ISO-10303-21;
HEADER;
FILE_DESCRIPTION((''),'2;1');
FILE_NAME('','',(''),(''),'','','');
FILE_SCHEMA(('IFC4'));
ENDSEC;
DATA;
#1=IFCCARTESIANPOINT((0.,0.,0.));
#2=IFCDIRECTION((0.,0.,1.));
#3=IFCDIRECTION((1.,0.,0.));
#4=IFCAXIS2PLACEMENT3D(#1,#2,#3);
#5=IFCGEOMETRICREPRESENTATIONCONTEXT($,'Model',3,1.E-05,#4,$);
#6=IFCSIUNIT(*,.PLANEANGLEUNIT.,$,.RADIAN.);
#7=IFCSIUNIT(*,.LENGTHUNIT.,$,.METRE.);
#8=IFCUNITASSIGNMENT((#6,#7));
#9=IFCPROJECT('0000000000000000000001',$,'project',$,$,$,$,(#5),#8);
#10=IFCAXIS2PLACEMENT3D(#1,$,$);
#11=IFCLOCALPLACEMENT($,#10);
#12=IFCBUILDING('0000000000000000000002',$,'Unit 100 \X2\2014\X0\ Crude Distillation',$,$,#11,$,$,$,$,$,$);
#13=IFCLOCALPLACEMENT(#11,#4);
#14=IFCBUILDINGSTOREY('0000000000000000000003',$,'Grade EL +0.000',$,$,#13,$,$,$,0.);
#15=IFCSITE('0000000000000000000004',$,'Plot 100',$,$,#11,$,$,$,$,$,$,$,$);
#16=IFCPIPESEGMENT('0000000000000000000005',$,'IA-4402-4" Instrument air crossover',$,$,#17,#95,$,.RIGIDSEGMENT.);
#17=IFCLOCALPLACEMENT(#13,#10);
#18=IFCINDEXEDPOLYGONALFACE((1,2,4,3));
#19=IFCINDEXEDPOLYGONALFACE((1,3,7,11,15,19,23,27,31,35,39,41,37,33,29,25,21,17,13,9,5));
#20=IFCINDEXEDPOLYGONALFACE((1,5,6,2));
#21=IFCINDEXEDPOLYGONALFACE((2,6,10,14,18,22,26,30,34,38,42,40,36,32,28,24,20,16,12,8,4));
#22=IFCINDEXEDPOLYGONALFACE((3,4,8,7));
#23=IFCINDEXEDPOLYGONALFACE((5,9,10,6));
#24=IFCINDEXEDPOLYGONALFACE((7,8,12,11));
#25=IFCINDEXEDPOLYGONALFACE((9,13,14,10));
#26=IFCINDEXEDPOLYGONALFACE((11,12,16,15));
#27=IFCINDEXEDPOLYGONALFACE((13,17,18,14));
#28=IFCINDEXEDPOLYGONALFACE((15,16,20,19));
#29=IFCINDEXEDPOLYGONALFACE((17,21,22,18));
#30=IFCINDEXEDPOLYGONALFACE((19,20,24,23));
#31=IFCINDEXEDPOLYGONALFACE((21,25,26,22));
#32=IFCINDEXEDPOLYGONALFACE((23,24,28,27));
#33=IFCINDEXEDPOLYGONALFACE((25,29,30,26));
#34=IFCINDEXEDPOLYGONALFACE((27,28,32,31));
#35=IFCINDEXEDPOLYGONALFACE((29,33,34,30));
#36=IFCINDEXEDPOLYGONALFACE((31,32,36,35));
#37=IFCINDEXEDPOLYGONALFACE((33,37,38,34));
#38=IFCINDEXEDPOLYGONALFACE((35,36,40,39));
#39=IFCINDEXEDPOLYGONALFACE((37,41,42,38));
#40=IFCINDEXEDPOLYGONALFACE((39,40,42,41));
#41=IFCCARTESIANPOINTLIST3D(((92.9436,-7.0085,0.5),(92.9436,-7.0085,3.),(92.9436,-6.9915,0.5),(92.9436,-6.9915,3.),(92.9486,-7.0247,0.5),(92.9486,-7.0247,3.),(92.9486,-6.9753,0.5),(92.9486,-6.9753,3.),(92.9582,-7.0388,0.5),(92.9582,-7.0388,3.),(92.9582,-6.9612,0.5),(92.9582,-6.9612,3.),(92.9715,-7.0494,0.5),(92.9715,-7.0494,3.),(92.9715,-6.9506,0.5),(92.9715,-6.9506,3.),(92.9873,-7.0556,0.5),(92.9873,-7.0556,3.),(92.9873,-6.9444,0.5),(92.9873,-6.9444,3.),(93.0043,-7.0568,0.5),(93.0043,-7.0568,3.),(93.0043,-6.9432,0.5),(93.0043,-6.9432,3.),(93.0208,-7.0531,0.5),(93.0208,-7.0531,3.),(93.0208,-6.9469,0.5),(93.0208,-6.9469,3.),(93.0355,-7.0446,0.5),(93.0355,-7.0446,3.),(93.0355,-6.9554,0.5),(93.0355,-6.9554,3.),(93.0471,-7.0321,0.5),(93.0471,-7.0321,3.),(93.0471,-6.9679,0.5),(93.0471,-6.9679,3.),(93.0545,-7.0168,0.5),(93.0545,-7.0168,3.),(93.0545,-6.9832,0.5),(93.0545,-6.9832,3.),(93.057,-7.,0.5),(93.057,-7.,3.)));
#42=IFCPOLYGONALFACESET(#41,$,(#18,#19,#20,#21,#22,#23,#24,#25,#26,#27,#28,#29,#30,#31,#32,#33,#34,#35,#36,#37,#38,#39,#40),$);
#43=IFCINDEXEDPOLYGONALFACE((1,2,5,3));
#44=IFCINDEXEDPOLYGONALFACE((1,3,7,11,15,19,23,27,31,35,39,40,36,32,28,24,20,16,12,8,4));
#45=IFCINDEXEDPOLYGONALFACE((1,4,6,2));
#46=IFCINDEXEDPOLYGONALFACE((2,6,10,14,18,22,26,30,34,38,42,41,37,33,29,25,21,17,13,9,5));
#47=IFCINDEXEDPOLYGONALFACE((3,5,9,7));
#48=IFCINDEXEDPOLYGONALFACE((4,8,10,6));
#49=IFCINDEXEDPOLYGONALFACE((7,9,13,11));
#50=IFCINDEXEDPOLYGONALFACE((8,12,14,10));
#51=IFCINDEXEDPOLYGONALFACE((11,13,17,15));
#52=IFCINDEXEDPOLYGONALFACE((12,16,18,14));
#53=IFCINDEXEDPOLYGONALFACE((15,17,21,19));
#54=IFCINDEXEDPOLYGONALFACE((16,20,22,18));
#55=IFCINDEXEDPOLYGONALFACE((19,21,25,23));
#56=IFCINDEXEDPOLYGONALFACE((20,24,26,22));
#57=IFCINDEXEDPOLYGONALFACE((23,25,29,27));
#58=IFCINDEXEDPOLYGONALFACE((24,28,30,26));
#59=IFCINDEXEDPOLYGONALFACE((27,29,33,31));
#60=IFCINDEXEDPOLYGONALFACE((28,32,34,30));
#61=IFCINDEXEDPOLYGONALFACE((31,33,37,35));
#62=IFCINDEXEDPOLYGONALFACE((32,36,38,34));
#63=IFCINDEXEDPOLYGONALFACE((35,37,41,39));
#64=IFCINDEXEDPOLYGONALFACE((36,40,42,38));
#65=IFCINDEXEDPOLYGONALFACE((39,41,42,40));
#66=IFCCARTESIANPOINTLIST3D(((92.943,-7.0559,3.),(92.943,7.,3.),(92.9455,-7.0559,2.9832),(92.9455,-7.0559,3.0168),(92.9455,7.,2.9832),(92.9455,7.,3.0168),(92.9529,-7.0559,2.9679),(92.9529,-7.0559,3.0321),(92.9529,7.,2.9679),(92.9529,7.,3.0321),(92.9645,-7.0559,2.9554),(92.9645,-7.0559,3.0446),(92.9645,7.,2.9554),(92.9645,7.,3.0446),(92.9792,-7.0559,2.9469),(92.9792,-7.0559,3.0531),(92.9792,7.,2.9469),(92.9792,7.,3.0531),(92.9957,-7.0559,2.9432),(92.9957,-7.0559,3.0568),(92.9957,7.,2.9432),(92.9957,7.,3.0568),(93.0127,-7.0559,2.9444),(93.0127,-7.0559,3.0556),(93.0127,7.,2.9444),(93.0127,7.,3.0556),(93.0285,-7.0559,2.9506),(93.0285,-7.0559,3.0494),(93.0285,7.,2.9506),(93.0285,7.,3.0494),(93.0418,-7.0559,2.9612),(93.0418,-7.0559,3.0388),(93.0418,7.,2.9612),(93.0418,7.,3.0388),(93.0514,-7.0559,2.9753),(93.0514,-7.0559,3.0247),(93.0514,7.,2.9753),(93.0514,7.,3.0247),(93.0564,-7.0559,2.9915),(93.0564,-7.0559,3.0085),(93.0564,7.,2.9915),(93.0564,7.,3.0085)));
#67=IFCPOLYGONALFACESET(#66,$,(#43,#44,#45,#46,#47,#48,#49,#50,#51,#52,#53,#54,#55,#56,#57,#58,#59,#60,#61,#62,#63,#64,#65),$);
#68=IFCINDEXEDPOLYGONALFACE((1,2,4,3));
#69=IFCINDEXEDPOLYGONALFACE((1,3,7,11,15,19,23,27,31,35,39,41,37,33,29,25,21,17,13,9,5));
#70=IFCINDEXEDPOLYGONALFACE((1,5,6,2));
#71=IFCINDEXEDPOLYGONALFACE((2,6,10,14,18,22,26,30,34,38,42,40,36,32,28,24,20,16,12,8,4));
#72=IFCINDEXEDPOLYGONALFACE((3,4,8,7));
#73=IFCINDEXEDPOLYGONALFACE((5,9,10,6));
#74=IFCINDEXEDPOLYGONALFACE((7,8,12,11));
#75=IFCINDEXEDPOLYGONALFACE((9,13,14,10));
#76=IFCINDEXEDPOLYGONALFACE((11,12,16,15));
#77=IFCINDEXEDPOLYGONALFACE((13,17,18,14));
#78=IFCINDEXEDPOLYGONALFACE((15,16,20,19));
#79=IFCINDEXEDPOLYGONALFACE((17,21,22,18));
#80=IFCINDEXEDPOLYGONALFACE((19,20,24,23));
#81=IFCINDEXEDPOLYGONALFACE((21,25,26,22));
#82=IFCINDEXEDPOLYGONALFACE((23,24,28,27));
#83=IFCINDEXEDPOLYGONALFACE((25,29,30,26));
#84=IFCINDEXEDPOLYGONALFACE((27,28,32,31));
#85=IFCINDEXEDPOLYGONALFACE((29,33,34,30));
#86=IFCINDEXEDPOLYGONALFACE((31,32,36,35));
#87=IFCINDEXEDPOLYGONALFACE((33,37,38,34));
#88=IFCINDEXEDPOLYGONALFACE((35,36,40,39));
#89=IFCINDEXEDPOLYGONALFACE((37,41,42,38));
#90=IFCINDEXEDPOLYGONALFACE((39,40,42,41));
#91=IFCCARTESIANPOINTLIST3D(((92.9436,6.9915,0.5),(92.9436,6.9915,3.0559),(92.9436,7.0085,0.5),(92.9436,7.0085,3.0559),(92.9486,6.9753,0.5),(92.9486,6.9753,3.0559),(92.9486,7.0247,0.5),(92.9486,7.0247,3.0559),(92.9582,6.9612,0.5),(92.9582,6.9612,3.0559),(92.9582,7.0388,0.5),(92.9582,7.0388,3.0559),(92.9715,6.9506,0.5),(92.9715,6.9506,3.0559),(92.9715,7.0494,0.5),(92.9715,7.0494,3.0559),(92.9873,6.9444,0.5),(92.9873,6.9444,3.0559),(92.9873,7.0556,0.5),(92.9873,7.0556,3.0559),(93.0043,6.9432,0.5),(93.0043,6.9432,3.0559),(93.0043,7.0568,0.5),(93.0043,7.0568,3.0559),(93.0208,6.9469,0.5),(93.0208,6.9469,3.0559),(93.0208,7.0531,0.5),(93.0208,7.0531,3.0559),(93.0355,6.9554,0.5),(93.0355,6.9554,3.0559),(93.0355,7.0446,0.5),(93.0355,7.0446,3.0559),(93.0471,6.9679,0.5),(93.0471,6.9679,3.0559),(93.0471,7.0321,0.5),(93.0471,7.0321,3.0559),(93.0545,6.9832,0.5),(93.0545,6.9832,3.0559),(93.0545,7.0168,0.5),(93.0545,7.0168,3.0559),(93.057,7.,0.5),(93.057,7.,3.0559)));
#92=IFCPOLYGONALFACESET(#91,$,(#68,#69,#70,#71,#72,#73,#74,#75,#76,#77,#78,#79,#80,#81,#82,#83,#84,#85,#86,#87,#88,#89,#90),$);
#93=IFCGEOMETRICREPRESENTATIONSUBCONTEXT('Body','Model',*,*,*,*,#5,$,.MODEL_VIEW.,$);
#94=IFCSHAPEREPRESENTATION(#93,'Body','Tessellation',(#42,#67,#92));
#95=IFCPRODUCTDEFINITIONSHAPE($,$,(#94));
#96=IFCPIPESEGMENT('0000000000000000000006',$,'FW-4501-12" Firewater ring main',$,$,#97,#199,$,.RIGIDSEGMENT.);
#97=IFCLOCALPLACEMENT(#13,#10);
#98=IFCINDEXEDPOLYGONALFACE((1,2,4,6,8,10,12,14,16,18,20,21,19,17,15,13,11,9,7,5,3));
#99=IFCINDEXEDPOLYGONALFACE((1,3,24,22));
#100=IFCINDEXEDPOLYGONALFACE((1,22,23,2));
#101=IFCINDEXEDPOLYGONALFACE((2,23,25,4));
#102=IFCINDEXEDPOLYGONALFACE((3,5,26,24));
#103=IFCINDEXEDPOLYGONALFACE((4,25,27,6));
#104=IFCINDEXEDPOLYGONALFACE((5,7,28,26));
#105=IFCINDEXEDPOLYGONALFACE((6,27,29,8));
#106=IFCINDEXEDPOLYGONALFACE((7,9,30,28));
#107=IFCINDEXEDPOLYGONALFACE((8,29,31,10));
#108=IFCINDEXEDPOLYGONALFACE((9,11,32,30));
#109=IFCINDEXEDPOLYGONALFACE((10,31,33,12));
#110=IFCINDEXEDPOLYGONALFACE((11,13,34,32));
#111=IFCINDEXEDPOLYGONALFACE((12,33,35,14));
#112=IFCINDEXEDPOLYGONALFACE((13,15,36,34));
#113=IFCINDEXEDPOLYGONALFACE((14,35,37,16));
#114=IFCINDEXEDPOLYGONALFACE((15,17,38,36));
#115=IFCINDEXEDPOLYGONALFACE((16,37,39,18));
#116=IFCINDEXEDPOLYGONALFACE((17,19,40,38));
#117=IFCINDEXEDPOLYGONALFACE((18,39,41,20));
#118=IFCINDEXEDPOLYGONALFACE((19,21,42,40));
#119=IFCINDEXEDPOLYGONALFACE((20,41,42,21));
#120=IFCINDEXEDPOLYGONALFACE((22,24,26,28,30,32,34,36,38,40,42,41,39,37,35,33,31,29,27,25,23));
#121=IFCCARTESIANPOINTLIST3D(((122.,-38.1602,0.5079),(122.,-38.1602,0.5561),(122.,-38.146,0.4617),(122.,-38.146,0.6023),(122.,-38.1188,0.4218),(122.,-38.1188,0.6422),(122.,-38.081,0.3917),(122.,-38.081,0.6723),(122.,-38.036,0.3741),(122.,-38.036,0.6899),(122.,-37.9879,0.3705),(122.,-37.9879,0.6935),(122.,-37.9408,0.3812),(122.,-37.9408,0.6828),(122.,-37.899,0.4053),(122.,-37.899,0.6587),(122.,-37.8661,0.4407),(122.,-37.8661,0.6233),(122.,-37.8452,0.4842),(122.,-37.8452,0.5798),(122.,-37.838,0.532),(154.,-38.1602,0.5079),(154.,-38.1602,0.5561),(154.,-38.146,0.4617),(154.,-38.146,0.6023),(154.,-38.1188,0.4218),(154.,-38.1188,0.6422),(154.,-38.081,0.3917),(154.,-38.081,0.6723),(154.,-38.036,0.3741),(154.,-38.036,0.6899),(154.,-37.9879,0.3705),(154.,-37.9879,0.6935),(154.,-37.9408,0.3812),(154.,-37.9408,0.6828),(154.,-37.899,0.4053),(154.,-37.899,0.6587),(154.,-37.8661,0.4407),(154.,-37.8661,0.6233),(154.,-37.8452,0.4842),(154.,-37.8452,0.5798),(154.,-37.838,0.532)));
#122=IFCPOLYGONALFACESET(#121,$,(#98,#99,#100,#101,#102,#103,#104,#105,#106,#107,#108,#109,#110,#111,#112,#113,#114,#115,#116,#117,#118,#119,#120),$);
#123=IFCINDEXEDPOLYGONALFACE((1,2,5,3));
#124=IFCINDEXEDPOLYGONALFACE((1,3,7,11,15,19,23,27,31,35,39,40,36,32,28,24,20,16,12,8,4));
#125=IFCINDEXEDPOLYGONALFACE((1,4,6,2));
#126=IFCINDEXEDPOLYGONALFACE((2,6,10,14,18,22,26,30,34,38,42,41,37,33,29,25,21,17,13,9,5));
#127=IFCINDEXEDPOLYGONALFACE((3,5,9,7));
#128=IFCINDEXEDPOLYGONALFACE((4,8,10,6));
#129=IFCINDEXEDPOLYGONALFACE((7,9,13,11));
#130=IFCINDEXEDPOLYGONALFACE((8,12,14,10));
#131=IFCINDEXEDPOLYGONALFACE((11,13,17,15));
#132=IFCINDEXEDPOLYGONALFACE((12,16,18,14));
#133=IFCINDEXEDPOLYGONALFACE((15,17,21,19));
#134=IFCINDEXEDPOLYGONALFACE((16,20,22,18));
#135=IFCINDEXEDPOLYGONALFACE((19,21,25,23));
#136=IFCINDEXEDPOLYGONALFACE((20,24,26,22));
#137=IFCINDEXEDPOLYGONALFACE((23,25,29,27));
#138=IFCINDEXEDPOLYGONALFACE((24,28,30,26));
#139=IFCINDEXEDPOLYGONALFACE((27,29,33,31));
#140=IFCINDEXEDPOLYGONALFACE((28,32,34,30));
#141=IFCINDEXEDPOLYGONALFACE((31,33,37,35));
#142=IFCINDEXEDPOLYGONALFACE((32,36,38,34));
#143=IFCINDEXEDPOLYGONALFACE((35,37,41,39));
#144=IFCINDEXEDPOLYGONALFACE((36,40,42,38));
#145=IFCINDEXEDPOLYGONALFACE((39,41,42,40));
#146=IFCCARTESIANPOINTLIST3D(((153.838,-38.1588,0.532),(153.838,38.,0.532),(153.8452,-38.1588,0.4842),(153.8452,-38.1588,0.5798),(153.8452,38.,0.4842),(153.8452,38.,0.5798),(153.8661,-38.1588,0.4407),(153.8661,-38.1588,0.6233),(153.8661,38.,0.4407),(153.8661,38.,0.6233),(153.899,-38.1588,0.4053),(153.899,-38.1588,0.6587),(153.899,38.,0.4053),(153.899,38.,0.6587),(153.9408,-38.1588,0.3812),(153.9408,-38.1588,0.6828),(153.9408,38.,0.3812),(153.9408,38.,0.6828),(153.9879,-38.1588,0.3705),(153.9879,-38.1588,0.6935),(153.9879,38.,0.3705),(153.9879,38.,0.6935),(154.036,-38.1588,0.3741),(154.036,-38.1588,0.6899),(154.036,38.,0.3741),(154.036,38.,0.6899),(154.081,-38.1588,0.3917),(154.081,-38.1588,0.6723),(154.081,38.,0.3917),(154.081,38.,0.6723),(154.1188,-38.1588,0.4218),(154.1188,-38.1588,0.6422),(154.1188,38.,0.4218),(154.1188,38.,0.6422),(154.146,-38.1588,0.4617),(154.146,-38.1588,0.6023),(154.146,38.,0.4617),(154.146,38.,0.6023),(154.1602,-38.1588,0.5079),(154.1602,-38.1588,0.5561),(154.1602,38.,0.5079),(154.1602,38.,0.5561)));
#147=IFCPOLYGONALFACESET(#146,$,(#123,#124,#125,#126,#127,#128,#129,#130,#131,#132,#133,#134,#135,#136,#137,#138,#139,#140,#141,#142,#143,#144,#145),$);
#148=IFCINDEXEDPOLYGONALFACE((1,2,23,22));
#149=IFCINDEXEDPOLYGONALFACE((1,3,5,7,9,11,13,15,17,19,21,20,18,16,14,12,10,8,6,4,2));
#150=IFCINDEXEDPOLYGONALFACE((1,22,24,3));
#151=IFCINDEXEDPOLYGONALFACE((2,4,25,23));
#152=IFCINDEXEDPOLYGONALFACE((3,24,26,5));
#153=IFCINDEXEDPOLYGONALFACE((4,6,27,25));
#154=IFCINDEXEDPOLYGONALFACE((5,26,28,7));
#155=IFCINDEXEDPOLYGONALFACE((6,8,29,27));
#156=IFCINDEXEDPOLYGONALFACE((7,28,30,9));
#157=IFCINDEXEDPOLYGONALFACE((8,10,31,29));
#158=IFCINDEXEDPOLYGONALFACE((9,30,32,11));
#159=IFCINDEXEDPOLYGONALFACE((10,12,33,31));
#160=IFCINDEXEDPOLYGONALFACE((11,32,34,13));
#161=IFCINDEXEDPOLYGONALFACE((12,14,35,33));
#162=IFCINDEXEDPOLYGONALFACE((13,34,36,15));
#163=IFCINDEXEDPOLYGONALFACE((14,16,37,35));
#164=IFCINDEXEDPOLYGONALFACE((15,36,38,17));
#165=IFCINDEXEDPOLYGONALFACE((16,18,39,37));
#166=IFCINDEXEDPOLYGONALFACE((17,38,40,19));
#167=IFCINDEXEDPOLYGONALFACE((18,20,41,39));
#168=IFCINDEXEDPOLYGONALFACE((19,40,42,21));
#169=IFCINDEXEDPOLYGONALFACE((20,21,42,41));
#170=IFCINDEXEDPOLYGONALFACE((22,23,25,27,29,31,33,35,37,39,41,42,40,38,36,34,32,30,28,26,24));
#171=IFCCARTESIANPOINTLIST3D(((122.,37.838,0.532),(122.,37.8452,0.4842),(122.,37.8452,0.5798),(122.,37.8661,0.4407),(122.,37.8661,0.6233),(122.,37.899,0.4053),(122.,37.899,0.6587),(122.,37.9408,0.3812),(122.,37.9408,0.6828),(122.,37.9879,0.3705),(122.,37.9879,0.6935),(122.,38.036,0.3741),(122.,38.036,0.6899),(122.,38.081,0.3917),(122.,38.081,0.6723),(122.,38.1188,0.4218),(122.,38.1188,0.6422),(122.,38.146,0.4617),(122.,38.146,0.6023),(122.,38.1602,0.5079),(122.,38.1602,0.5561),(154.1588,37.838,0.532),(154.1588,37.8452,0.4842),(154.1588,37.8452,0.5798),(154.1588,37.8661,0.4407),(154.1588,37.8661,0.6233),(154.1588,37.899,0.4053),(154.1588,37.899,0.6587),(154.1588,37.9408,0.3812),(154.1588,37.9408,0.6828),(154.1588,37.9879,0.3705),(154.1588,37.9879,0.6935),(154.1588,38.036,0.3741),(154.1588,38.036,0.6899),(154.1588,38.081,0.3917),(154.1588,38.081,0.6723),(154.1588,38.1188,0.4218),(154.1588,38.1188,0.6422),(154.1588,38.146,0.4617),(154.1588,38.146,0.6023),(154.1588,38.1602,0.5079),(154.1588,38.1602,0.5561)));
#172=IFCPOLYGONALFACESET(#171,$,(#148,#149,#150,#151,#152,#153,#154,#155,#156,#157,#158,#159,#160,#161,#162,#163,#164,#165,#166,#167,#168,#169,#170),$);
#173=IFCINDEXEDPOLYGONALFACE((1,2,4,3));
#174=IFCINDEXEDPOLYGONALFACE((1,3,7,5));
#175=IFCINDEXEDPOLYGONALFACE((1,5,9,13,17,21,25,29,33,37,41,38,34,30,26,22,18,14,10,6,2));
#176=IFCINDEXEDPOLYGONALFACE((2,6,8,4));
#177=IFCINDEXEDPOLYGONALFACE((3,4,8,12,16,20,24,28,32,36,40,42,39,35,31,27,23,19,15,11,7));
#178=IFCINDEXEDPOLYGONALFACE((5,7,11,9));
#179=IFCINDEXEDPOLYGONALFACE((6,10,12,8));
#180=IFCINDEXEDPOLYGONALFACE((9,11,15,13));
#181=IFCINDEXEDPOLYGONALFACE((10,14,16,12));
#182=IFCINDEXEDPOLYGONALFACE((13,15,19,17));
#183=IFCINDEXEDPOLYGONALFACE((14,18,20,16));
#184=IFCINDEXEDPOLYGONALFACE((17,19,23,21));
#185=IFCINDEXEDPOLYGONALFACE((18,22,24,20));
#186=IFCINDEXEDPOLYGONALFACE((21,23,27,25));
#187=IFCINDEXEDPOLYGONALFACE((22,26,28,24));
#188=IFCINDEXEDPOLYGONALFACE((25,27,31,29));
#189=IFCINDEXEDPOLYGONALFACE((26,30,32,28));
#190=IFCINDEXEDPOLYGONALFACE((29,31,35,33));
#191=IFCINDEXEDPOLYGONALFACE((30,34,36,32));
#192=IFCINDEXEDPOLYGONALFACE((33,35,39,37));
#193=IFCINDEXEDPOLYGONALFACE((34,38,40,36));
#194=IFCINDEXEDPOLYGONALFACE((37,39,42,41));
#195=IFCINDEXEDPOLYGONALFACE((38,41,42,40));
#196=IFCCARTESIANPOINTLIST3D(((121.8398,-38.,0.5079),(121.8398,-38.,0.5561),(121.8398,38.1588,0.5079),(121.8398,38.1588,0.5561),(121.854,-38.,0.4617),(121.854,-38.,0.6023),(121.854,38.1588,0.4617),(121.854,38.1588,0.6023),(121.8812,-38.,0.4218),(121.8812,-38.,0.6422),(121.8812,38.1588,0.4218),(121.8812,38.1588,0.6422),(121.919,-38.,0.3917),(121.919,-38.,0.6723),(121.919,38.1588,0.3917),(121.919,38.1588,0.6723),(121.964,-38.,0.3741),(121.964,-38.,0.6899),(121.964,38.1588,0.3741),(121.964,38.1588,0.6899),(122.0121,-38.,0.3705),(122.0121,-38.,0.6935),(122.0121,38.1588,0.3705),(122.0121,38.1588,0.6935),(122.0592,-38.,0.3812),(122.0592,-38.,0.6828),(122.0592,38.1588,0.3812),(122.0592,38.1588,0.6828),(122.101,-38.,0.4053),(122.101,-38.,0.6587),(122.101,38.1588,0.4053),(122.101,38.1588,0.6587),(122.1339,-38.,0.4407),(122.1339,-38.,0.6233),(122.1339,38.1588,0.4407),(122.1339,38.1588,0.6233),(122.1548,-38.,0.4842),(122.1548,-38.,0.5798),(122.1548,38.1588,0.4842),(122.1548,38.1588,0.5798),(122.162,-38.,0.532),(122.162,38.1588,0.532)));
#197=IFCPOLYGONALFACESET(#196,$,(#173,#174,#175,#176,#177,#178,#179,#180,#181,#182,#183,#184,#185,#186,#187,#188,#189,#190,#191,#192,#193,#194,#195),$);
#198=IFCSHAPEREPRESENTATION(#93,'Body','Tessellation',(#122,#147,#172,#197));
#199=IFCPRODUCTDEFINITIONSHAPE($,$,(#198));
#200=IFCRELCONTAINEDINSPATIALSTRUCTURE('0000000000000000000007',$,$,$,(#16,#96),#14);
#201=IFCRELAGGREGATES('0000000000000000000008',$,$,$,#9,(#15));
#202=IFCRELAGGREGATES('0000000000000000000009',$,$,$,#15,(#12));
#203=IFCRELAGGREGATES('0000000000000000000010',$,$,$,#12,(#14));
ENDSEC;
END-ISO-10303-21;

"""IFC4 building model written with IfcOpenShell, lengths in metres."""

from ifc_helpers import new_model, si_unit, frame, origin, origin_with_axes, origin_2d, place, context, subcontext, project, spatial, circle, extrude, element, save


model = new_model("IFC4")

# Units and contexts
model_context = context("Model", 3, precision=1e-05, world=origin_with_axes())
body_context = subcontext(model_context, "Body", "Model", "MODEL_VIEW")
ifc_project = project(units=[si_unit("PLANEANGLEUNIT", "RADIAN"), si_unit("LENGTHUNIT", "METRE")], contexts=[model_context])

# Site, building, storey
placement = place(None, origin())
site = spatial("IfcSite", under=ifc_project, at=placement, Name="Plot 100")
building = spatial("IfcBuilding", under=site, at=placement, Name="Unit 100 — Crude Distillation")
storey_placement = place(placement, origin_with_axes())
storey = spatial("IfcBuildingStorey", under=building, at=storey_placement, Name="Grade EL +0.000", Elevation=0.0)

# Pipe segments
pipe_segment_1_placement = place(storey_placement, origin_with_axes())
element("IfcPipeSegment", 1, at=pipe_segment_1_placement, inside=storey, Name="IA-4402-4\" Instrument air crossover", PredefinedType="RIGIDSEGMENT", context=body_context, shape_type="SweptSolid", body=[
    extrude(circle(Radius=0.057, at=origin_2d()), frame((93.0, -7.0, 0.5), z_axis=(0.0, 0.0, 1.0), x_axis=(1.0, 0.0, 0.0)), (0.0, 0.0, 1.0), 2.5),
    extrude(circle(Radius=0.057, at=origin_2d()), frame((93.0, -7.0559, 3.0), z_axis=(0.0, 1.0, 0.0), x_axis=(-1.0, 0.0, 0.0)), (0.0, 0.0, 1.0), 14.0559),
    extrude(circle(Radius=0.057, at=origin_2d()), frame((93.0, 7.0, 3.0559), z_axis=(0.0, 0.0, -1.0), x_axis=(1.0, 0.0, 0.0)), (0.0, 0.0, 1.0), 2.5559),
])
pipe_segment_2_placement = place(storey_placement, origin_with_axes())
element("IfcPipeSegment", 2, at=pipe_segment_2_placement, inside=storey, Name="FW-4501-12\" Firewater ring main", PredefinedType="RIGIDSEGMENT", context=body_context, shape_type="SweptSolid", body=[
    extrude(circle(Radius=0.162, at=origin_2d()), frame((122.0, -38.0, 0.532), z_axis=(1.0, 0.0, 0.0), x_axis=(0.0, 1.0, 0.0)), (0.0, 0.0, 1.0), 32.0),
    extrude(circle(Radius=0.162, at=origin_2d()), frame((154.0, -38.1588, 0.532), z_axis=(0.0, 1.0, 0.0), x_axis=(-1.0, 0.0, 0.0)), (0.0, 0.0, 1.0), 76.1588),
    extrude(circle(Radius=0.162, at=origin_2d()), frame((154.1588, 38.0, 0.532), z_axis=(-1.0, 0.0, 0.0), x_axis=(0.0, -1.0, 0.0)), (0.0, 0.0, 1.0), 32.1588),
    extrude(circle(Radius=0.162, at=origin_2d()), frame((122.0, 38.1588, 0.532), z_axis=(0.0, -1.0, 0.0), x_axis=(1.0, 0.0, 0.0)), (0.0, 0.0, 1.0), 76.1588),
])

save(model, "model.ifc")
